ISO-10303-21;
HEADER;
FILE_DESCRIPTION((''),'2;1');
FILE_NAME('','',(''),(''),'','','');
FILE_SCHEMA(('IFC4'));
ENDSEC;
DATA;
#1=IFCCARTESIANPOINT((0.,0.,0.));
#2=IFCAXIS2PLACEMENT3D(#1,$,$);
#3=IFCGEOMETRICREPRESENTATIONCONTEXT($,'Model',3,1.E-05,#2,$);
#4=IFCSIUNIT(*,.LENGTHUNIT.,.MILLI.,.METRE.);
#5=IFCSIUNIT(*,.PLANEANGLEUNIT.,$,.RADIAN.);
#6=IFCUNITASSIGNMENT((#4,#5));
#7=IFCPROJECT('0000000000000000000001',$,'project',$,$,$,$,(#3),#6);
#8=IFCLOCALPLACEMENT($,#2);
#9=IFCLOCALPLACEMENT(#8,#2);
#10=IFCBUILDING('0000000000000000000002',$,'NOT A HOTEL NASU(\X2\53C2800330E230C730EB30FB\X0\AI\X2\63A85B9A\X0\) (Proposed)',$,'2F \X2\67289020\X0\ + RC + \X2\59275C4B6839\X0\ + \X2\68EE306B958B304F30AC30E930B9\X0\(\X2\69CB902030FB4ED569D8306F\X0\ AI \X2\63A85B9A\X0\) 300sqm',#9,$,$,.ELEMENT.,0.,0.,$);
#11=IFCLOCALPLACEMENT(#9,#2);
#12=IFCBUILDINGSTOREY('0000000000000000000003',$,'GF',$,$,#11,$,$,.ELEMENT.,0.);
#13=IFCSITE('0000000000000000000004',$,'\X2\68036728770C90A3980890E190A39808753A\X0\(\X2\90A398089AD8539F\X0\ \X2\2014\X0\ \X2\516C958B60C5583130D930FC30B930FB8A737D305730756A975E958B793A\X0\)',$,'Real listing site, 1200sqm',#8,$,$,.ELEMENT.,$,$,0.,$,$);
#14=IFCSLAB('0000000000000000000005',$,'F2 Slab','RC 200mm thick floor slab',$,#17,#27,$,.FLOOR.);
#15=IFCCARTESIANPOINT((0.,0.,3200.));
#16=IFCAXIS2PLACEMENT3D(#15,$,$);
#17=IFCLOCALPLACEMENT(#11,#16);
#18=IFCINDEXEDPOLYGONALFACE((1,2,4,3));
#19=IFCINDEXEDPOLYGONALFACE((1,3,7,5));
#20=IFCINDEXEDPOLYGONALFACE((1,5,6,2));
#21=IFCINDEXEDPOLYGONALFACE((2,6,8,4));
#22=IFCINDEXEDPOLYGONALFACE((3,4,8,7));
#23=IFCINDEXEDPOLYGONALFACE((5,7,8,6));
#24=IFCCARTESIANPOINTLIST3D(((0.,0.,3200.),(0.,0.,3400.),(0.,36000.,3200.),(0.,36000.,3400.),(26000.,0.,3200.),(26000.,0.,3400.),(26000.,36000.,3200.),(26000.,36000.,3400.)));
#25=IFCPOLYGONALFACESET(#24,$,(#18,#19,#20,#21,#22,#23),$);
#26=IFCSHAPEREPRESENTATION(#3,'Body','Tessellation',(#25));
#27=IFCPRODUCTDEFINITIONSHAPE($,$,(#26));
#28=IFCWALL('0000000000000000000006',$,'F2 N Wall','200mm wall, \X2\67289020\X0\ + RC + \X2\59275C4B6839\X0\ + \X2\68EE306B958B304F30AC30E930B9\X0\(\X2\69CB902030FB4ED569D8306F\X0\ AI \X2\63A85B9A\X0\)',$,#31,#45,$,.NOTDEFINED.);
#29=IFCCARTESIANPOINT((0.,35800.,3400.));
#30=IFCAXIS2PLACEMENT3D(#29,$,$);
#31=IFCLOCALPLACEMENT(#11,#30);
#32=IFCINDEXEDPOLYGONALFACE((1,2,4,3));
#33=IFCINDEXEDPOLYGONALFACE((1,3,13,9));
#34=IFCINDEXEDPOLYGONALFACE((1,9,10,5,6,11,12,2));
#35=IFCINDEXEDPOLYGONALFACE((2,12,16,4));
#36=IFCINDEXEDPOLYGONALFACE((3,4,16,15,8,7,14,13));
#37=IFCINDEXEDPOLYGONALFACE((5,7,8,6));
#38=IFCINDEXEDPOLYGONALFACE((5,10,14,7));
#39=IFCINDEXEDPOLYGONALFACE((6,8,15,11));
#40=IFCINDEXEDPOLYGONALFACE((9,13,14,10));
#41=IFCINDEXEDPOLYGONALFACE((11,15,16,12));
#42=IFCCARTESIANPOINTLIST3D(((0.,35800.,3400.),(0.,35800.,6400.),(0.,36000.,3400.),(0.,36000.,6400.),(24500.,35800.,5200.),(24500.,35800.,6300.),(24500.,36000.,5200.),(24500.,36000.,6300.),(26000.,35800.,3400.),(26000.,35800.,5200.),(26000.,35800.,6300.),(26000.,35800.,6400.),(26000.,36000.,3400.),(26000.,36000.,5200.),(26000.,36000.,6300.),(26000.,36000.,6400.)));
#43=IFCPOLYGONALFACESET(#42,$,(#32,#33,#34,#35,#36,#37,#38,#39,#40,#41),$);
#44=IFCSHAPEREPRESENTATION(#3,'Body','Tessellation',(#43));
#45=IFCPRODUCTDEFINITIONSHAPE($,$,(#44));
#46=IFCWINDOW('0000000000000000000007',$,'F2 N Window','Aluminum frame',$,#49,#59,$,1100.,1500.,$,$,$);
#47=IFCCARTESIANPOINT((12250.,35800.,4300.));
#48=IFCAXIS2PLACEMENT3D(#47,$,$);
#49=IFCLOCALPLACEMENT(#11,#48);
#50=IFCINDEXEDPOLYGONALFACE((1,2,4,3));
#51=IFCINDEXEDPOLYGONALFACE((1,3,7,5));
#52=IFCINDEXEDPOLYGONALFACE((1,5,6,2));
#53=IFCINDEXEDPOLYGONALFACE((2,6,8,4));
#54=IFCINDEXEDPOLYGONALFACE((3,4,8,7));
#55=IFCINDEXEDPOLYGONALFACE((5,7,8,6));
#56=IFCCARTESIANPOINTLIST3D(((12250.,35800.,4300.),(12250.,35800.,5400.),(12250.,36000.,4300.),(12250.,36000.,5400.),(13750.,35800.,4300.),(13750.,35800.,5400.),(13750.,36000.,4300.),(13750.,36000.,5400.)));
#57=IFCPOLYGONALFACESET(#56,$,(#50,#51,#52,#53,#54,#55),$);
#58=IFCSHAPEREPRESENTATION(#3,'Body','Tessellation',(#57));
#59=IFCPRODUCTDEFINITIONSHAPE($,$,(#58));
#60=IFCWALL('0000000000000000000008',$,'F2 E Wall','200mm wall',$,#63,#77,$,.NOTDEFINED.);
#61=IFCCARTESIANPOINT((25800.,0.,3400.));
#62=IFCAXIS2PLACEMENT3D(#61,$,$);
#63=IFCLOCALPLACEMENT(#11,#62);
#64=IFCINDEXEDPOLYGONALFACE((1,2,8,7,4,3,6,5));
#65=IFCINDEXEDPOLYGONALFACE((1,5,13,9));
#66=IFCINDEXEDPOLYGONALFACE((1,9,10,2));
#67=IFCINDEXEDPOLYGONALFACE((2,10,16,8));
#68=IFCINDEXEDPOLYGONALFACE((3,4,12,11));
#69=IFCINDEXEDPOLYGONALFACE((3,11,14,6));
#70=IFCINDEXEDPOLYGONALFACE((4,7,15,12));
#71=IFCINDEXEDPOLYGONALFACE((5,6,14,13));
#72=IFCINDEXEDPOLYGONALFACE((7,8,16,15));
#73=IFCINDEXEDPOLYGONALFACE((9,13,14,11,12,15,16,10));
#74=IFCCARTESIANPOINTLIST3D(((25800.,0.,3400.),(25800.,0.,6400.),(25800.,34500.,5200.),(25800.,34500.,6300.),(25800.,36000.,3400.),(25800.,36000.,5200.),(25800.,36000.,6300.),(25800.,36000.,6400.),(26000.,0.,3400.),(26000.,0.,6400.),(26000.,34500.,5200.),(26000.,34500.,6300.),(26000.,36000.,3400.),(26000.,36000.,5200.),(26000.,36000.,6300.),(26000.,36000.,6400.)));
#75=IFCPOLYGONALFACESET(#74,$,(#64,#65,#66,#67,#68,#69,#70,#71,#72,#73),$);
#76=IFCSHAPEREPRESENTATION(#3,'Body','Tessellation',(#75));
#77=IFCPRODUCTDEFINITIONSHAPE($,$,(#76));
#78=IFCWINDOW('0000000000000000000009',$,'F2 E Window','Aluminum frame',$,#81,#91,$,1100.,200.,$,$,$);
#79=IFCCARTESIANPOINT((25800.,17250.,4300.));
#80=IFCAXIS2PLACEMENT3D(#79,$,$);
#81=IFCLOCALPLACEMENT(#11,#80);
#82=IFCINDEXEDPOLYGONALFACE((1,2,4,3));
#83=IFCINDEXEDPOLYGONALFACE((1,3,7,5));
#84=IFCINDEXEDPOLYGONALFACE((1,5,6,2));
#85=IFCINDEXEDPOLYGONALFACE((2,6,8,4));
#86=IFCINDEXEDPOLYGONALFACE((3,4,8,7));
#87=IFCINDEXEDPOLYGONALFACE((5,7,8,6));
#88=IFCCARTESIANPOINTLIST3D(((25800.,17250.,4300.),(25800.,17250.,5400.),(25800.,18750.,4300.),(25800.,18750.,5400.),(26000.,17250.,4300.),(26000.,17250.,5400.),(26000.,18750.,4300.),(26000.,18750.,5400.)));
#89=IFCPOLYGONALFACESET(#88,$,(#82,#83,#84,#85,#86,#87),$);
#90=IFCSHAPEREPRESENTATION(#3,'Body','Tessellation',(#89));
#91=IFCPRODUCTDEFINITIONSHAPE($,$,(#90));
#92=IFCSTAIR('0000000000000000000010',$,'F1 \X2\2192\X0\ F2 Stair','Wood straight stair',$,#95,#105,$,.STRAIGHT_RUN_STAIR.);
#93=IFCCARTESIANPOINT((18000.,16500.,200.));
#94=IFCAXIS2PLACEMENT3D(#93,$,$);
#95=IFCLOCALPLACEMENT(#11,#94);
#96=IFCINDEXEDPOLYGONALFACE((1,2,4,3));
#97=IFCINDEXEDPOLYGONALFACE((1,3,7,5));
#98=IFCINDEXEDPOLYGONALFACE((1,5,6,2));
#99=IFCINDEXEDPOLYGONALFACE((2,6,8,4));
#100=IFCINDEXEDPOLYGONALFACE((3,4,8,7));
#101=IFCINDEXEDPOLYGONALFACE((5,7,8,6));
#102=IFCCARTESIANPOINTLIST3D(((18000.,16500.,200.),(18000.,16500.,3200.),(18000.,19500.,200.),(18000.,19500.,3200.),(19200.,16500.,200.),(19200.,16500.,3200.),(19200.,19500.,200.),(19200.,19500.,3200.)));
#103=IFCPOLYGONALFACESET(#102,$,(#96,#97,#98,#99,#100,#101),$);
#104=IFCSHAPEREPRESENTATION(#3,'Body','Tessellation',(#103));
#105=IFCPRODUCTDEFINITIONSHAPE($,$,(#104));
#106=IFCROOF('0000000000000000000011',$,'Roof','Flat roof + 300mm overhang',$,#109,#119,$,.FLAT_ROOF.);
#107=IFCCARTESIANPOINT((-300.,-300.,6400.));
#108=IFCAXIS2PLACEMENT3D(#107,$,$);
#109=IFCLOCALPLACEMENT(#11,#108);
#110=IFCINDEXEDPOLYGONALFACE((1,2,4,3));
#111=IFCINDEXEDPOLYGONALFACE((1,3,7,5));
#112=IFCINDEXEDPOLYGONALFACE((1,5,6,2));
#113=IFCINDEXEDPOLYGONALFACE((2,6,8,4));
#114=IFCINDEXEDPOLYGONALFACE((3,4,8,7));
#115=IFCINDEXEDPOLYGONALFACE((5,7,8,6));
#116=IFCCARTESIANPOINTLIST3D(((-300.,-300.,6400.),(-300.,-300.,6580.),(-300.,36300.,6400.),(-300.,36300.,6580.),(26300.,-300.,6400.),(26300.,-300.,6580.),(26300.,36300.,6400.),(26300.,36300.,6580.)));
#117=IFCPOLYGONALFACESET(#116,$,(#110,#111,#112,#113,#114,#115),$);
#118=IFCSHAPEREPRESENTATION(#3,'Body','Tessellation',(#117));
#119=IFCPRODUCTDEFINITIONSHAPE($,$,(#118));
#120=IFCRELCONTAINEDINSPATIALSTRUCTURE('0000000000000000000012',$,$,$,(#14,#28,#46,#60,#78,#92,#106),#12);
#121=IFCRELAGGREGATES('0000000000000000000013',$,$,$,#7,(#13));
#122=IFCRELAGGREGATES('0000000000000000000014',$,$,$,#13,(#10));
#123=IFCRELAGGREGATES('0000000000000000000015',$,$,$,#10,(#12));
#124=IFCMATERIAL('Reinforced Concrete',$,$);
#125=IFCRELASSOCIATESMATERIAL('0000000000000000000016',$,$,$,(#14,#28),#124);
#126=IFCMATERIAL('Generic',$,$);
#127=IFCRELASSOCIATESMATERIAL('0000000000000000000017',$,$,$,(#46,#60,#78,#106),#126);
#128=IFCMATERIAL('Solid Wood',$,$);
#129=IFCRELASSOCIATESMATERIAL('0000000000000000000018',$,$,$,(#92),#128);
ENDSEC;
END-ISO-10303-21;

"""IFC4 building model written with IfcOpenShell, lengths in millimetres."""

from ifc_helpers import new_model, si_unit, frame, frame_2d, origin, place, context, project, spatial, rectangle, extrude, material, element, fill, save


model = new_model("IFC4")

# Units and contexts
model_context = context("Model", 3, precision=1e-05, world=origin())
ifc_project = project(units=[si_unit("LENGTHUNIT", "METRE", prefix="MILLI"), si_unit("PLANEANGLEUNIT", "RADIAN")], contexts=[model_context])

# Site, building, storey
site_placement = place(None, origin())
site = spatial("IfcSite", under=ifc_project, at=site_placement, Name="栃木県那須郡那須町(那須高原 — 公開情報ベース・詳細地番非開示)", ObjectType="Real listing site, 1200sqm", CompositionType="ELEMENT", RefElevation=0.0)
building_placement = place(site_placement, origin())
building = spatial("IfcBuilding", under=site, at=building_placement, Name="NOT A HOTEL NASU(参考モデル・AI推定) (Proposed)", ObjectType="2F 木造 + RC + 大屋根 + 森に開くガラス(構造・仕様は AI 推定) 300sqm", CompositionType="ELEMENT", ElevationOfRefHeight=0.0, ElevationOfTerrain=0.0)
storey_placement = place(building_placement, origin())
storey = spatial("IfcBuildingStorey", under=building, at=storey_placement, Name="GF", CompositionType="ELEMENT", Elevation=0.0)

# Slab
ifc_material_1 = material(Name="Reinforced Concrete")
slab_1_placement = place(storey_placement, frame((0.0, 0.0, 3200.0)))
element("IfcSlab", 1, at=slab_1_placement, inside=storey, material=ifc_material_1, Name="F2 Slab", Description="RC 200mm thick floor slab", PredefinedType="FLOOR", context=model_context, shape_type="SweptSolid", body=[
    extrude(rectangle(XDim=26000.0, YDim=36000.0, at=frame_2d((13000.0, 18000.0))), frame((0.0, 0.0, 3200.0)), (0.0, 0.0, 1.0), 200.0),
])

# Shared definitions
ifc_material_2 = material(Name="Generic")

# Shared definitions
ifc_material_3 = material(Name="Solid Wood")

# Walls, openings, windows
wall_1_placement = place(storey_placement, frame((0.0, 35800.0, 3400.0)))
wall_1 = element("IfcWall", 2, at=wall_1_placement, inside=storey, material=ifc_material_1, Name="F2 N Wall", Description="200mm wall, 木造 + RC + 大屋根 + 森に開くガラス(構造・仕様は AI 推定)", PredefinedType="NOTDEFINED", context=model_context, shape_type="SweptSolid", body=[
    extrude(rectangle(XDim=26000.0, YDim=200.0, at=frame_2d((13000.0, 100.0))), frame((0.0, 35800.0, 3400.0)), (0.0, 0.0, 1.0), 3000.0),
])
opening_1_placement = place(storey_placement, frame((12250.0, 35800.0, 4300.0)))
opening_1 = element("IfcOpeningElement", 3, at=opening_1_placement, cuts=wall_1, PredefinedType="NOTDEFINED", context=model_context, shape_type="SweptSolid", body=[
    extrude(rectangle(XDim=1500.0, YDim=200.0, at=frame_2d((750.0, 100.0))), frame((12250.0, 35800.0, 4300.0)), (0.0, 0.0, 1.0), 1100.0),
])
window_1_placement = place(storey_placement, frame((12250.0, 35800.0, 4300.0)))
window_1 = element("IfcWindow", 4, at=window_1_placement, inside=storey, material=ifc_material_2, Name="F2 N Window", Description="Aluminum frame", OverallHeight=1100.0, OverallWidth=1500.0, context=model_context, shape_type="SweptSolid", body=[
    extrude(rectangle(XDim=1500.0, YDim=200.0, at=frame_2d((750.0, 100.0))), frame((12250.0, 35800.0, 4300.0)), (0.0, 0.0, 1.0), 1100.0),
])
fill(opening_1, window_1)
wall_2_placement = place(storey_placement, frame((25800.0, 0.0, 3400.0)))
wall_2 = element("IfcWall", 5, at=wall_2_placement, inside=storey, material=ifc_material_2, Name="F2 E Wall", Description="200mm wall", PredefinedType="NOTDEFINED", context=model_context, shape_type="SweptSolid", body=[
    extrude(rectangle(XDim=200.0, YDim=36000.0, at=frame_2d((100.0, 18000.0))), frame((25800.0, 0.0, 3400.0)), (0.0, 0.0, 1.0), 3000.0),
])
opening_2_placement = place(storey_placement, frame((25800.0, 17250.0, 4300.0)))
opening_2 = element("IfcOpeningElement", 6, at=opening_2_placement, cuts=wall_2, PredefinedType="NOTDEFINED", context=model_context, shape_type="SweptSolid", body=[
    extrude(rectangle(XDim=200.0, YDim=1500.0, at=frame_2d((100.0, 750.0))), frame((25800.0, 17250.0, 4300.0)), (0.0, 0.0, 1.0), 1100.0),
])
window_2_placement = place(storey_placement, frame((25800.0, 17250.0, 4300.0)))
window_2 = element("IfcWindow", 7, at=window_2_placement, inside=storey, material=ifc_material_2, Name="F2 E Window", Description="Aluminum frame", OverallHeight=1100.0, OverallWidth=200.0, context=model_context, shape_type="SweptSolid", body=[
    extrude(rectangle(XDim=200.0, YDim=1500.0, at=frame_2d((100.0, 750.0))), frame((25800.0, 17250.0, 4300.0)), (0.0, 0.0, 1.0), 1100.0),
])
fill(opening_2, window_2)

# Stair
stair_placement = place(storey_placement, frame((18000.0, 16500.0, 200.0)))
element("IfcStair", 8, at=stair_placement, inside=storey, material=ifc_material_3, Name="F1 → F2 Stair", Description="Wood straight stair", PredefinedType="STRAIGHT_RUN_STAIR", context=model_context, shape_type="SweptSolid", body=[
    extrude(rectangle(XDim=1200.0, YDim=3000.0, at=frame_2d((600.0, 1500.0))), frame((18000.0, 16500.0, 200.0)), (0.0, 0.0, 1.0), 3000.0),
])

# Roof
roof_placement = place(storey_placement, frame((-300.0, -300.0, 6400.0)))
element("IfcRoof", 9, at=roof_placement, inside=storey, material=ifc_material_2, Name="Roof", Description="Flat roof + 300mm overhang", PredefinedType="FLAT_ROOF", context=model_context, shape_type="SweptSolid", body=[
    extrude(rectangle(XDim=26600.0, YDim=36600.0, at=frame_2d((13300.0, 18300.0))), frame((-300.0, -300.0, 6400.0)), (0.0, 0.0, 1.0), 180.0),
])

save(model, "model.ifc")
